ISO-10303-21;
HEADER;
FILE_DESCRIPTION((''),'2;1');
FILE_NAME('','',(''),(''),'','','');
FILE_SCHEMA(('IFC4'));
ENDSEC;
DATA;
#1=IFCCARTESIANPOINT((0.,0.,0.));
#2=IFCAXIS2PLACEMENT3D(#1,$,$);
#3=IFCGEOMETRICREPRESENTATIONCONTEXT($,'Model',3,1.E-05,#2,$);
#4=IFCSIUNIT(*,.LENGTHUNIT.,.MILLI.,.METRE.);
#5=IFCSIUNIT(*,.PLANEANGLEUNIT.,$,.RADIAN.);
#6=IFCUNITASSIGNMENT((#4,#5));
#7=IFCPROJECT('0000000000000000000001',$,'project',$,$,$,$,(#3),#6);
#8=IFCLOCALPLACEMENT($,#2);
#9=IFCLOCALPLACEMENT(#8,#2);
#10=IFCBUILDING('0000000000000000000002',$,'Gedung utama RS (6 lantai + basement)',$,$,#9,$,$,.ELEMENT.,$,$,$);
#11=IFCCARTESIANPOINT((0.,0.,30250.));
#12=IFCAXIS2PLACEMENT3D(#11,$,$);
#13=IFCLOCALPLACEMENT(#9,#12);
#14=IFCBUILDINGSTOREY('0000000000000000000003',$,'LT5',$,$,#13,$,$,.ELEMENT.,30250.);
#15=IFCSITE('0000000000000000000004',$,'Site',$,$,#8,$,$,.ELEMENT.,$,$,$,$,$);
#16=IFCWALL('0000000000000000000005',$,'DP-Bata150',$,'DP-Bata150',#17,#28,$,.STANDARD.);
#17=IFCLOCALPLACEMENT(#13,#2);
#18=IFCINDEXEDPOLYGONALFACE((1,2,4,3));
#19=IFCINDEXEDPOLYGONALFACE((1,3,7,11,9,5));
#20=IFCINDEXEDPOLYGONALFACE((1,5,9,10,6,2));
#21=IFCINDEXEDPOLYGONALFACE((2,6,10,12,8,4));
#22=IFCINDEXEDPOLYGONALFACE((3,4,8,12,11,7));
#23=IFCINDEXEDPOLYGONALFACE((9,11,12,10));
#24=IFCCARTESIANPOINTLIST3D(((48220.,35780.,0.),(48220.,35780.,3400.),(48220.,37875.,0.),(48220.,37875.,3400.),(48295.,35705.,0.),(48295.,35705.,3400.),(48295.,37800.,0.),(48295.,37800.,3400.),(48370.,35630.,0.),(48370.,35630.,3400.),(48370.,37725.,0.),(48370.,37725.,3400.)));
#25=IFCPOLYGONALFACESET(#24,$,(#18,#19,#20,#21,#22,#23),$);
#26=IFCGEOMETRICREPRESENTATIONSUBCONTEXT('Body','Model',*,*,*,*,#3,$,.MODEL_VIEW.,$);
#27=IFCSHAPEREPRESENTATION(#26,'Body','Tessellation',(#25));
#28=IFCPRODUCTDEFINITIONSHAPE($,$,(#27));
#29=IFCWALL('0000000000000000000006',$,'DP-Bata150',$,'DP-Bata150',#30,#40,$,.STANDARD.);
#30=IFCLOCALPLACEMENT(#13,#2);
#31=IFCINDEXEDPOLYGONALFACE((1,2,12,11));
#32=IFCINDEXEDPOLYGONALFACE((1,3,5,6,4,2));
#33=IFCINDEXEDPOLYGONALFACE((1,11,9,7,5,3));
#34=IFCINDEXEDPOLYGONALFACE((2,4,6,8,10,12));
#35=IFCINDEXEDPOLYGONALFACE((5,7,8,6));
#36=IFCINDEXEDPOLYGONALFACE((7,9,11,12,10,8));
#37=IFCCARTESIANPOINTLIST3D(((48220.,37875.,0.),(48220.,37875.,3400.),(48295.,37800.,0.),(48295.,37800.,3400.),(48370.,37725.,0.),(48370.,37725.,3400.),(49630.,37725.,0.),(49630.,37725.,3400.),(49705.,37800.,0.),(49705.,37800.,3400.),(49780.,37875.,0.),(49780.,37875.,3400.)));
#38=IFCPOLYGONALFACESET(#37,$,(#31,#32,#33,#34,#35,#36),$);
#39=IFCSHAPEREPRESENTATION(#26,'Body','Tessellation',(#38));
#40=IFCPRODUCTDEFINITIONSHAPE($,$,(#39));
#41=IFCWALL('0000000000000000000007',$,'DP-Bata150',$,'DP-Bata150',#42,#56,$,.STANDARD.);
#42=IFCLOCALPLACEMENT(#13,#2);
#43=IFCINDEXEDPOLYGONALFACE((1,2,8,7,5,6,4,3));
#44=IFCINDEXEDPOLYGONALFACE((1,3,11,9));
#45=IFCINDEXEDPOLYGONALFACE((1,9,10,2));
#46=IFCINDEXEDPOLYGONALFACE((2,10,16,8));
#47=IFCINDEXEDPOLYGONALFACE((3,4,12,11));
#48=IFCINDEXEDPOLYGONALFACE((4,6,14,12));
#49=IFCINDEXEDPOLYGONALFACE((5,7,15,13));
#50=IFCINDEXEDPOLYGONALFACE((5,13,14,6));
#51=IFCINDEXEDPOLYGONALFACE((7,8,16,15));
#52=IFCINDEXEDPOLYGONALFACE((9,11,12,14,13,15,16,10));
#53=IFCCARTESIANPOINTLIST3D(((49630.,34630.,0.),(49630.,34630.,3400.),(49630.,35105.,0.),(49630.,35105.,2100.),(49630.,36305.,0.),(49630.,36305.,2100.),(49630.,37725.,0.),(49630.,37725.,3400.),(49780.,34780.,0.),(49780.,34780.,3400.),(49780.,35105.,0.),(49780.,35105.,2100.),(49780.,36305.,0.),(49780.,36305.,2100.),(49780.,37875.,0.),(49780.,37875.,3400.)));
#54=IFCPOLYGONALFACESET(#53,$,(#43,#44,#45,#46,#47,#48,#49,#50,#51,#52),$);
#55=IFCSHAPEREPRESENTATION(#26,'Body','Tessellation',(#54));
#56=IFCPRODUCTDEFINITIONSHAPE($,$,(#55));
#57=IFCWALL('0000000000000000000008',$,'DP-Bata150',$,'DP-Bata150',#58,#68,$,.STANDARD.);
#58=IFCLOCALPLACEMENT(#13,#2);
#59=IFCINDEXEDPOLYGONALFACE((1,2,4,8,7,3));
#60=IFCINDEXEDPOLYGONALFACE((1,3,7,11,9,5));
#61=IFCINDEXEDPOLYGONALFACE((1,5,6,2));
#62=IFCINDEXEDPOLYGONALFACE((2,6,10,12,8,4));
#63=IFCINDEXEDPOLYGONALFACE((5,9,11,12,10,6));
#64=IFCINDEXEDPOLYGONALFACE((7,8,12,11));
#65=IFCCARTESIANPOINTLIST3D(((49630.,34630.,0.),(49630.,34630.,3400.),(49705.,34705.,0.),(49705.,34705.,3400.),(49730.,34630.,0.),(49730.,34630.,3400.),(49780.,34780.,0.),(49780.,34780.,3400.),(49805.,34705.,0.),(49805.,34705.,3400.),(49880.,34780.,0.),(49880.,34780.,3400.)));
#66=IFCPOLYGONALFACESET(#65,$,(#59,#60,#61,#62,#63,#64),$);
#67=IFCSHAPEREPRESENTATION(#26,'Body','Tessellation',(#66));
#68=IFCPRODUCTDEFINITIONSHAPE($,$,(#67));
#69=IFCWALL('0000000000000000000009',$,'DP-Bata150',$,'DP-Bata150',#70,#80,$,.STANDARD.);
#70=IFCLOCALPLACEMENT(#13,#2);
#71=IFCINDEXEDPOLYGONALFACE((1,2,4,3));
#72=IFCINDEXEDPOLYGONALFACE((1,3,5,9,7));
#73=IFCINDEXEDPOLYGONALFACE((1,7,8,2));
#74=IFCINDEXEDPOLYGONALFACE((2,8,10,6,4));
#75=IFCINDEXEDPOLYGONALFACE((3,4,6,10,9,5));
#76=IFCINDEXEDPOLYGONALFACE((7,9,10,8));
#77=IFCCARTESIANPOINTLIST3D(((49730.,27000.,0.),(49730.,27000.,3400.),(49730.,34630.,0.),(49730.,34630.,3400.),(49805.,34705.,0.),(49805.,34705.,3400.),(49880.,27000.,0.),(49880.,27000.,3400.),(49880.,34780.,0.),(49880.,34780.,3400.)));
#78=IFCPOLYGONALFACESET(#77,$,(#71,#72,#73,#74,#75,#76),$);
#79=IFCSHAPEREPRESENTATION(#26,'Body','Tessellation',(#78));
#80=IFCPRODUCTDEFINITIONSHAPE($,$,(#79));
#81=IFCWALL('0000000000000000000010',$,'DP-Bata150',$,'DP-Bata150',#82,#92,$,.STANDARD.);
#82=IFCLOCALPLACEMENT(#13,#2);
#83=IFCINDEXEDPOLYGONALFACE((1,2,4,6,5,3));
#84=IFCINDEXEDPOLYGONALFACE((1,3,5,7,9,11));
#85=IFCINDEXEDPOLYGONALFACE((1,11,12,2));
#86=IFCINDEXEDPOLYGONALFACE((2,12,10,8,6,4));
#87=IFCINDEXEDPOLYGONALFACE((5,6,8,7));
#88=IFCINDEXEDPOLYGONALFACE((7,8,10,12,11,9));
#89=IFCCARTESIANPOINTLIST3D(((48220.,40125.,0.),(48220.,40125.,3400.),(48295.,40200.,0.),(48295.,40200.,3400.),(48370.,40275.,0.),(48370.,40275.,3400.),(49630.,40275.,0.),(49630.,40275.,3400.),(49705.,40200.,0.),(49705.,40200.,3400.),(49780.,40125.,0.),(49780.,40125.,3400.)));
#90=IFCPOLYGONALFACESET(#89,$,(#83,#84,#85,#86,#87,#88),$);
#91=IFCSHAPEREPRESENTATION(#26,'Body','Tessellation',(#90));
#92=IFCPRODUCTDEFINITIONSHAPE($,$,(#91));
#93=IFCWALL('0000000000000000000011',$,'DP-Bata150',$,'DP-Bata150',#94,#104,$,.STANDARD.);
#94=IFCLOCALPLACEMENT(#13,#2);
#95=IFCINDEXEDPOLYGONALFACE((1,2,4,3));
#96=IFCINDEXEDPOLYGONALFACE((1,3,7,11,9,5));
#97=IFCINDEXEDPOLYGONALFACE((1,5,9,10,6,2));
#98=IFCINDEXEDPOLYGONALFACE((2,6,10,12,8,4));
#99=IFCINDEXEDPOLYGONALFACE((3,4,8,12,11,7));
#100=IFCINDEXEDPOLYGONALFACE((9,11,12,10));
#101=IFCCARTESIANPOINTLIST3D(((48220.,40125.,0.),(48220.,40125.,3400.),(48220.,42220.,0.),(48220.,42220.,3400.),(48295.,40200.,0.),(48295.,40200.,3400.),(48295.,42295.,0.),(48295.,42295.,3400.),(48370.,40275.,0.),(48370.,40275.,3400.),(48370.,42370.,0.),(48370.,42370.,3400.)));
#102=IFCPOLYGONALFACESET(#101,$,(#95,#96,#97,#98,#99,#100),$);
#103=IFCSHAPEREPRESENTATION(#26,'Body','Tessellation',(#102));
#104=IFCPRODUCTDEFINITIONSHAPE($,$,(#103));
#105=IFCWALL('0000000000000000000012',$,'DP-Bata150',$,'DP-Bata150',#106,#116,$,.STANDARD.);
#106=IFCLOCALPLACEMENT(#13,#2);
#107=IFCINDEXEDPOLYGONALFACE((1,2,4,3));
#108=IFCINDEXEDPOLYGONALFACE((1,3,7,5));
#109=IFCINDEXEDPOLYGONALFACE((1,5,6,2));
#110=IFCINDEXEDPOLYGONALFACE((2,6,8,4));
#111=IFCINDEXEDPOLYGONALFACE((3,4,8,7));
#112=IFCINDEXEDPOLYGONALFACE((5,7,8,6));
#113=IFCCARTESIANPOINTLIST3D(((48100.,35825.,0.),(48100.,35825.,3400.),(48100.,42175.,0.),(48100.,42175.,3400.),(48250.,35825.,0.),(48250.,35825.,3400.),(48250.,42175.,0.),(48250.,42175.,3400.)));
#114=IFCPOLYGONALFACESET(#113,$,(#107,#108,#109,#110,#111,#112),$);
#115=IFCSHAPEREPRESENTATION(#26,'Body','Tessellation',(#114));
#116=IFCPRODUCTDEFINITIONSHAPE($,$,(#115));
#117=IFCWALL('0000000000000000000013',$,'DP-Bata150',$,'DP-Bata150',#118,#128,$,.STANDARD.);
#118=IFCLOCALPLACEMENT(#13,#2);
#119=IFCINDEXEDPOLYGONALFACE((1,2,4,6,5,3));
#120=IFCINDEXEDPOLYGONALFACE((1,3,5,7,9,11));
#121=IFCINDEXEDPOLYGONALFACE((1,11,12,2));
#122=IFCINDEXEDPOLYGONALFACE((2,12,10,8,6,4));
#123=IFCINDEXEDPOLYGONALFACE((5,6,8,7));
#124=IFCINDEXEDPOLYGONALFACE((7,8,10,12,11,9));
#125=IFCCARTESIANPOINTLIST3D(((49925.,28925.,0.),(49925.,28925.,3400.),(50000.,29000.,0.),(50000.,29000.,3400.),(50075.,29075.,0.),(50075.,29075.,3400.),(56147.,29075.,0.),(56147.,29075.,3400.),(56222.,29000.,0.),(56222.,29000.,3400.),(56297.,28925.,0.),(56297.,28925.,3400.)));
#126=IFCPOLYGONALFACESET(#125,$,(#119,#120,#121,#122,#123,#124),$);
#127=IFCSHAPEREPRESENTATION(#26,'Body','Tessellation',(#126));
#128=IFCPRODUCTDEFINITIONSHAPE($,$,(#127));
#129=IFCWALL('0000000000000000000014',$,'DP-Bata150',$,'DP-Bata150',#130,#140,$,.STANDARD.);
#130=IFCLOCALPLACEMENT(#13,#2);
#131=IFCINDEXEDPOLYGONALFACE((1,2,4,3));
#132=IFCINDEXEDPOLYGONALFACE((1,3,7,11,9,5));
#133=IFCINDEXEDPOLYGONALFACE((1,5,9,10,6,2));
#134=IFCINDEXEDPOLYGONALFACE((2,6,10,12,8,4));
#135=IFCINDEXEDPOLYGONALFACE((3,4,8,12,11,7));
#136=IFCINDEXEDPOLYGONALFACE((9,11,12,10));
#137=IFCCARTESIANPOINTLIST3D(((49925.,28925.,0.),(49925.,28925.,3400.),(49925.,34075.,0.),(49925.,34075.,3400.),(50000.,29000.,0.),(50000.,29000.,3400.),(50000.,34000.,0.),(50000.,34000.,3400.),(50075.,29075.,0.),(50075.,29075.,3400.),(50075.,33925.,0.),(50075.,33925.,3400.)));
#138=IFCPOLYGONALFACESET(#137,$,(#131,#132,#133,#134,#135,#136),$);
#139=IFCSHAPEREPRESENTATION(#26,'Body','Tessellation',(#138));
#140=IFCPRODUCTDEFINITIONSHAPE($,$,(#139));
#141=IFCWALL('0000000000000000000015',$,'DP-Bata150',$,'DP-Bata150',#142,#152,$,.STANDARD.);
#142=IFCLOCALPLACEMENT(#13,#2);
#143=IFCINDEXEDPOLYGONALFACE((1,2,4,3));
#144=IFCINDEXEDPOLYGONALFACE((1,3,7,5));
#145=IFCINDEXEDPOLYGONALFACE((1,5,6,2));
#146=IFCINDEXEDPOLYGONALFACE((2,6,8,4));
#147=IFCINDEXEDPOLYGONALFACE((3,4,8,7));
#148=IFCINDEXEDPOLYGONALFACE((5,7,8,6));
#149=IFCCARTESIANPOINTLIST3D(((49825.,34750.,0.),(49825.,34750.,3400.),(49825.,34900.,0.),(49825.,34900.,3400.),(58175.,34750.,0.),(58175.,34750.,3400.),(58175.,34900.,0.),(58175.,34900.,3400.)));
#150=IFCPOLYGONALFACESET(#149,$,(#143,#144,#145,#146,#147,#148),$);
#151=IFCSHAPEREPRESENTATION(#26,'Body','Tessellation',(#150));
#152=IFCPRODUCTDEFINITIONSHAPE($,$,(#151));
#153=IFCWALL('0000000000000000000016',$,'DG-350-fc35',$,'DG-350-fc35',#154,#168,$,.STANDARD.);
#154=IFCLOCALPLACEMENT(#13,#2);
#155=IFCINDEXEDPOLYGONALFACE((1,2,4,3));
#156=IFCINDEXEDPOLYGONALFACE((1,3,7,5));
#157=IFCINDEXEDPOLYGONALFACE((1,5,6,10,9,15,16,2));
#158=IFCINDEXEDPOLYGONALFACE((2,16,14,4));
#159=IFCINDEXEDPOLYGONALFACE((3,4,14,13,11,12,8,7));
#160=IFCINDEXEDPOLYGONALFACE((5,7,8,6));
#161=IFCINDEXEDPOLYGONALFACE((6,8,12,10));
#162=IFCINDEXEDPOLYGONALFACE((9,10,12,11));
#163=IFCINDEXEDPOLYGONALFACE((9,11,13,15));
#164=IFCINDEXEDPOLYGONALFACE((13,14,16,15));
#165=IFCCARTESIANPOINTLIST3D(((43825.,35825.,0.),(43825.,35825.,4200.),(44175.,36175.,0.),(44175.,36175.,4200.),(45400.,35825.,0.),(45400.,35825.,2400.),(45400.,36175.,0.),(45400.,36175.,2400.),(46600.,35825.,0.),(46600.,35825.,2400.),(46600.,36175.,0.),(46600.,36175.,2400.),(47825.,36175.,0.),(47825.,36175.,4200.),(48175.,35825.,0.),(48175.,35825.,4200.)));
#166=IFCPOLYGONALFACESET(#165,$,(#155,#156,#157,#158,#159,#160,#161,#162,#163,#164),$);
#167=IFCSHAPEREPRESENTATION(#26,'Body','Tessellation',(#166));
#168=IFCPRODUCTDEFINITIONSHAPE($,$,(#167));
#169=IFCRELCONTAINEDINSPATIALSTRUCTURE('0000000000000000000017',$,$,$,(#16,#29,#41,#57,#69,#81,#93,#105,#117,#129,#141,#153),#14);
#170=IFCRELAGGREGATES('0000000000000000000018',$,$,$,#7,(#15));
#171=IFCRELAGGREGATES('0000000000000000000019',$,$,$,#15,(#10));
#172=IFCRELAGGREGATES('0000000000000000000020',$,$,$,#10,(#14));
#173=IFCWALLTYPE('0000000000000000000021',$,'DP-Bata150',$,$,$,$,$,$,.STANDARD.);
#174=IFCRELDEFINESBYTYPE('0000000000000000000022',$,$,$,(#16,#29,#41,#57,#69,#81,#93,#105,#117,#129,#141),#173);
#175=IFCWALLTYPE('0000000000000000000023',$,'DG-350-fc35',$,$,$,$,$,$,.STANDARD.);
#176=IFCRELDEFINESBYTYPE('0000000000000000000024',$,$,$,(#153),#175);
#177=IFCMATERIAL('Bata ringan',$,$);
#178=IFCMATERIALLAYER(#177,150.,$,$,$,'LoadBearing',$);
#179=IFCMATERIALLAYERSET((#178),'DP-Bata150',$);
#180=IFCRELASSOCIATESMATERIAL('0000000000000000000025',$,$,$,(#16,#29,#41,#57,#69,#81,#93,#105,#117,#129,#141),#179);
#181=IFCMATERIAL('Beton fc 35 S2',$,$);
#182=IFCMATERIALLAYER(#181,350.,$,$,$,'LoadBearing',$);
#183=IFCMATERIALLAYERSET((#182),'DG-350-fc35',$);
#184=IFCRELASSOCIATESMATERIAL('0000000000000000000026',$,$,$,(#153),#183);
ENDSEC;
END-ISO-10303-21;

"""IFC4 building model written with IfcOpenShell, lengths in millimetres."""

from ifc_helpers import new_model, si_unit, frame, frame_2d, origin, place, context, subcontext, project, spatial, polyline, rectangle, outline, extrude, material, layer, layer_set, layer_usage, type_object, element, save


model = new_model("IFC4")

# Units and contexts
model_context = context("Model", 3, precision=1e-05, world=origin())
body_context = subcontext(model_context, "Body", "Model", "MODEL_VIEW")
ifc_project = project(units=[si_unit("LENGTHUNIT", "METRE", prefix="MILLI"), si_unit("PLANEANGLEUNIT", "RADIAN")], contexts=[model_context])

# Site, building, storey
site_placement = place(None, origin())
site = spatial("IfcSite", under=ifc_project, at=site_placement, Name="Site", CompositionType="ELEMENT")
building_placement = place(site_placement, origin())
building = spatial("IfcBuilding", under=site, at=building_placement, Name="Gedung utama RS (6 lantai + basement)", CompositionType="ELEMENT")
storey_placement = place(building_placement, frame((0.0, 0.0, 30250.0)))
storey = spatial("IfcBuildingStorey", under=building, at=storey_placement, Name="LT5", CompositionType="ELEMENT", Elevation=30250.0)

# Walls
ifc_material_1 = material(Name="Bata ringan")
ifc_layer_1 = layer(ifc_material_1, 150.0, Category="LoadBearing")
ifc_layer_set_1 = layer_set([ifc_layer_1], Name="DP-Bata150")
ifc_layer_usage_1 = layer_usage(ifc_layer_set_1, "AXIS2", "NEGATIVE", 75.0)
wall_type_1 = type_object("IfcWallType", Name="DP-Bata150", PredefinedType="STANDARD")
wall_1_placement = place(storey_placement, frame((48295.0, 35705.0, 0.0), z_axis=(0.0, 0.0, 1.0), x_axis=(0.0, 1.0, 0.0)))
element("IfcWall", 1, at=wall_1_placement, inside=storey, type_object=wall_type_1, material=ifc_layer_usage_1, Name="DP-Bata150", ObjectType="DP-Bata150", PredefinedType="STANDARD", context=body_context, shape_type="SweptSolid", body=[
    extrude(outline(polyline([(-75.0, -75.0), (0.0, 0.0), (75.0, 75.0), (2170.0, 75.0), (2095.0, 0.0), (2020.0, -75.0), (-75.0, -75.0)])), origin(), (0.0, 0.0, 1.0), 3400.0),
])
wall_2_placement = place(storey_placement, frame((48295.0, 37800.0, 0.0), z_axis=(0.0, 0.0, 1.0), x_axis=(1.0, 0.0, 0.0)))
element("IfcWall", 2, at=wall_2_placement, inside=storey, type_object=wall_type_1, material=ifc_layer_usage_1, Name="DP-Bata150", ObjectType="DP-Bata150", PredefinedType="STANDARD", context=body_context, shape_type="SweptSolid", body=[
    extrude(outline(polyline([(75.0, -75.0), (0.0, 0.0), (-75.0, 75.0), (1485.0, 75.0), (1410.0, 0.0), (1335.0, -75.0), (75.0, -75.0)])), origin(), (0.0, 0.0, 1.0), 3400.0),
])

# Wall, opening
wall_3_placement = place(storey_placement, frame((49705.0, 37800.0, 0.0), z_axis=(0.0, 0.0, 1.0), x_axis=(0.0, -1.0, 0.0)))
wall_3 = element("IfcWall", 3, at=wall_3_placement, inside=storey, type_object=wall_type_1, material=ifc_layer_usage_1, Name="DP-Bata150", ObjectType="DP-Bata150", PredefinedType="STANDARD", context=body_context, shape_type="SweptSolid", body=[
    extrude(outline(polyline([(75.0, -75.0), (0.0, 0.0), (-75.0, 75.0), (3020.0, 75.0), (3095.0, 0.0), (3170.0, -75.0), (75.0, -75.0)])), origin(), (0.0, 0.0, 1.0), 3400.0),
])
opening_1_placement = place(wall_3_placement, frame((1495.0, 0.0, 0.0), z_axis=(0.0, 0.0, 1.0), x_axis=(1.0, 0.0, 0.0)))
element("IfcOpeningElement", 4, at=opening_1_placement, cuts=wall_3, PredefinedType="OPENING", context=body_context, shape_type="SweptSolid", body=[
    extrude(rectangle(XDim=1200.0, YDim=170.0, at=frame_2d((600.0, 0.0))), origin(), (0.0, 0.0, 1.0), 2100.0),
])

# Walls
wall_4_placement = place(storey_placement, frame((49705.0, 34705.0, 0.0), z_axis=(0.0, 0.0, 1.0), x_axis=(1.0, 0.0, 0.0)))
element("IfcWall", 5, at=wall_4_placement, inside=storey, type_object=wall_type_1, material=ifc_layer_usage_1, Name="DP-Bata150", ObjectType="DP-Bata150", PredefinedType="STANDARD", context=body_context, shape_type="SweptSolid", body=[
    extrude(outline(polyline([(-75.0, -75.0), (0.0, 0.0), (75.0, 75.0), (175.0, 75.0), (100.0, 0.0), (25.0, -75.0), (-75.0, -75.0)])), origin(), (0.0, 0.0, 1.0), 3400.0),
])
wall_5_placement = place(storey_placement, frame((49805.0, 34705.0, 0.0), z_axis=(0.0, 0.0, 1.0), x_axis=(0.0, -1.0, 0.0)))
element("IfcWall", 6, at=wall_5_placement, inside=storey, type_object=wall_type_1, material=ifc_layer_usage_1, Name="DP-Bata150", ObjectType="DP-Bata150", PredefinedType="STANDARD", context=body_context, shape_type="SweptSolid", body=[
    extrude(outline(polyline([(75.0, -75.0), (0.0, 0.0), (-75.0, 75.0), (7705.0, 75.0), (7705.0, -75.0), (75.0, -75.0)])), origin(), (0.0, 0.0, 1.0), 3400.0),
])
wall_6_placement = place(storey_placement, frame((49705.0, 40200.0, 0.0), z_axis=(0.0, 0.0, 1.0), x_axis=(-1.0, 0.0, 0.0)))
element("IfcWall", 7, at=wall_6_placement, inside=storey, type_object=wall_type_1, material=ifc_layer_usage_1, Name="DP-Bata150", ObjectType="DP-Bata150", PredefinedType="STANDARD", context=body_context, shape_type="SweptSolid", body=[
    extrude(outline(polyline([(75.0, -75.0), (0.0, 0.0), (-75.0, 75.0), (1485.0, 75.0), (1410.0, 0.0), (1335.0, -75.0), (75.0, -75.0)])), origin(), (0.0, 0.0, 1.0), 3400.0),
])
wall_7_placement = place(storey_placement, frame((48295.0, 40200.0, 0.0), z_axis=(0.0, 0.0, 1.0), x_axis=(0.0, 1.0, 0.0)))
element("IfcWall", 8, at=wall_7_placement, inside=storey, type_object=wall_type_1, material=ifc_layer_usage_1, Name="DP-Bata150", ObjectType="DP-Bata150", PredefinedType="STANDARD", context=body_context, shape_type="SweptSolid", body=[
    extrude(outline(polyline([(75.0, -75.0), (0.0, 0.0), (-75.0, 75.0), (2020.0, 75.0), (2095.0, 0.0), (2170.0, -75.0), (75.0, -75.0)])), origin(), (0.0, 0.0, 1.0), 3400.0),
])
wall_8_placement = place(storey_placement, frame((48175.0, 35825.0, 0.0), z_axis=(0.0, 0.0, 1.0), x_axis=(0.0, 1.0, 0.0)))
element("IfcWall", 9, at=wall_8_placement, inside=storey, type_object=wall_type_1, material=ifc_layer_usage_1, Name="DP-Bata150", ObjectType="DP-Bata150", PredefinedType="STANDARD", context=body_context, shape_type="SweptSolid", body=[
    extrude(outline(polyline([(0.0, -75.0), (0.0, 75.0), (6350.0, 75.0), (6350.0, -75.0), (0.0, -75.0)])), origin(), (0.0, 0.0, 1.0), 3400.0),
])
wall_9_placement = place(storey_placement, frame((50000.0, 29000.0, 0.0), z_axis=(0.0, 0.0, 1.0), x_axis=(1.0, 0.0, 0.0)))
element("IfcWall", 10, at=wall_9_placement, inside=storey, type_object=wall_type_1, material=ifc_layer_usage_1, Name="DP-Bata150", ObjectType="DP-Bata150", PredefinedType="STANDARD", context=body_context, shape_type="SweptSolid", body=[
    extrude(outline(polyline([(-75.0, -75.0), (0.0, 0.0), (75.0, 75.0), (6147.0, 75.0), (6222.0, 0.0), (6297.0, -75.0), (-75.0, -75.0)])), origin(), (0.0, 0.0, 1.0), 3400.0),
])
wall_10_placement = place(storey_placement, frame((50000.0, 34000.0, 0.0), z_axis=(0.0, 0.0, 1.0), x_axis=(0.0, -1.0, 0.0)))
element("IfcWall", 11, at=wall_10_placement, inside=storey, type_object=wall_type_1, material=ifc_layer_usage_1, Name="DP-Bata150", ObjectType="DP-Bata150", PredefinedType="STANDARD", context=body_context, shape_type="SweptSolid", body=[
    extrude(outline(polyline([(-75.0, -75.0), (0.0, 0.0), (75.0, 75.0), (4925.0, 75.0), (5000.0, 0.0), (5075.0, -75.0), (-75.0, -75.0)])), origin(), (0.0, 0.0, 1.0), 3400.0),
])
wall_11_placement = place(storey_placement, frame((49825.0, 34825.0, 0.0), z_axis=(0.0, 0.0, 1.0), x_axis=(1.0, 0.0, 0.0)))
element("IfcWall", 12, at=wall_11_placement, inside=storey, type_object=wall_type_1, material=ifc_layer_usage_1, Name="DP-Bata150", ObjectType="DP-Bata150", PredefinedType="STANDARD", context=body_context, shape_type="SweptSolid", body=[
    extrude(outline(polyline([(0.0, -75.0), (0.0, 75.0), (8350.0, 75.0), (8350.0, -75.0), (0.0, -75.0)])), origin(), (0.0, 0.0, 1.0), 3400.0),
])

# Wall, opening
ifc_material_2 = material(Name="Beton fc 35 S2")
ifc_layer_2 = layer(ifc_material_2, 350.0, Category="LoadBearing")
ifc_layer_set_2 = layer_set([ifc_layer_2], Name="DG-350-fc35")
ifc_layer_usage_2 = layer_usage(ifc_layer_set_2, "AXIS2", "NEGATIVE", 175.0)
wall_type_2 = type_object("IfcWallType", Name="DG-350-fc35", PredefinedType="STANDARD")
wall_12_placement = place(storey_placement, frame((44000.0, 36000.0, 0.0), z_axis=(0.0, 0.0, 1.0), x_axis=(1.0, 0.0, 0.0)))
wall_12 = element("IfcWall", 13, at=wall_12_placement, inside=storey, type_object=wall_type_2, material=ifc_layer_usage_2, Name="DG-350-fc35", ObjectType="DG-350-fc35", PredefinedType="STANDARD", context=body_context, shape_type="SweptSolid", body=[
    extrude(outline(polyline([(-175.0, -175.0), (0.0, 0.0), (175.0, 175.0), (3825.0, 175.0), (4000.0, 0.0), (4175.0, -175.0), (-175.0, -175.0)])), origin(), (0.0, 0.0, 1.0), 4200.0),
])
opening_2_placement = place(wall_12_placement, frame((1400.0, 0.0, 0.0), z_axis=(0.0, 0.0, 1.0), x_axis=(1.0, 0.0, 0.0)))
element("IfcOpeningElement", 14, at=opening_2_placement, cuts=wall_12, PredefinedType="OPENING", context=body_context, shape_type="SweptSolid", body=[
    extrude(rectangle(XDim=1200.0, YDim=370.0, at=frame_2d((600.0, 0.0))), origin(), (0.0, 0.0, 1.0), 2400.0),
])

save(model, "model.ifc")
